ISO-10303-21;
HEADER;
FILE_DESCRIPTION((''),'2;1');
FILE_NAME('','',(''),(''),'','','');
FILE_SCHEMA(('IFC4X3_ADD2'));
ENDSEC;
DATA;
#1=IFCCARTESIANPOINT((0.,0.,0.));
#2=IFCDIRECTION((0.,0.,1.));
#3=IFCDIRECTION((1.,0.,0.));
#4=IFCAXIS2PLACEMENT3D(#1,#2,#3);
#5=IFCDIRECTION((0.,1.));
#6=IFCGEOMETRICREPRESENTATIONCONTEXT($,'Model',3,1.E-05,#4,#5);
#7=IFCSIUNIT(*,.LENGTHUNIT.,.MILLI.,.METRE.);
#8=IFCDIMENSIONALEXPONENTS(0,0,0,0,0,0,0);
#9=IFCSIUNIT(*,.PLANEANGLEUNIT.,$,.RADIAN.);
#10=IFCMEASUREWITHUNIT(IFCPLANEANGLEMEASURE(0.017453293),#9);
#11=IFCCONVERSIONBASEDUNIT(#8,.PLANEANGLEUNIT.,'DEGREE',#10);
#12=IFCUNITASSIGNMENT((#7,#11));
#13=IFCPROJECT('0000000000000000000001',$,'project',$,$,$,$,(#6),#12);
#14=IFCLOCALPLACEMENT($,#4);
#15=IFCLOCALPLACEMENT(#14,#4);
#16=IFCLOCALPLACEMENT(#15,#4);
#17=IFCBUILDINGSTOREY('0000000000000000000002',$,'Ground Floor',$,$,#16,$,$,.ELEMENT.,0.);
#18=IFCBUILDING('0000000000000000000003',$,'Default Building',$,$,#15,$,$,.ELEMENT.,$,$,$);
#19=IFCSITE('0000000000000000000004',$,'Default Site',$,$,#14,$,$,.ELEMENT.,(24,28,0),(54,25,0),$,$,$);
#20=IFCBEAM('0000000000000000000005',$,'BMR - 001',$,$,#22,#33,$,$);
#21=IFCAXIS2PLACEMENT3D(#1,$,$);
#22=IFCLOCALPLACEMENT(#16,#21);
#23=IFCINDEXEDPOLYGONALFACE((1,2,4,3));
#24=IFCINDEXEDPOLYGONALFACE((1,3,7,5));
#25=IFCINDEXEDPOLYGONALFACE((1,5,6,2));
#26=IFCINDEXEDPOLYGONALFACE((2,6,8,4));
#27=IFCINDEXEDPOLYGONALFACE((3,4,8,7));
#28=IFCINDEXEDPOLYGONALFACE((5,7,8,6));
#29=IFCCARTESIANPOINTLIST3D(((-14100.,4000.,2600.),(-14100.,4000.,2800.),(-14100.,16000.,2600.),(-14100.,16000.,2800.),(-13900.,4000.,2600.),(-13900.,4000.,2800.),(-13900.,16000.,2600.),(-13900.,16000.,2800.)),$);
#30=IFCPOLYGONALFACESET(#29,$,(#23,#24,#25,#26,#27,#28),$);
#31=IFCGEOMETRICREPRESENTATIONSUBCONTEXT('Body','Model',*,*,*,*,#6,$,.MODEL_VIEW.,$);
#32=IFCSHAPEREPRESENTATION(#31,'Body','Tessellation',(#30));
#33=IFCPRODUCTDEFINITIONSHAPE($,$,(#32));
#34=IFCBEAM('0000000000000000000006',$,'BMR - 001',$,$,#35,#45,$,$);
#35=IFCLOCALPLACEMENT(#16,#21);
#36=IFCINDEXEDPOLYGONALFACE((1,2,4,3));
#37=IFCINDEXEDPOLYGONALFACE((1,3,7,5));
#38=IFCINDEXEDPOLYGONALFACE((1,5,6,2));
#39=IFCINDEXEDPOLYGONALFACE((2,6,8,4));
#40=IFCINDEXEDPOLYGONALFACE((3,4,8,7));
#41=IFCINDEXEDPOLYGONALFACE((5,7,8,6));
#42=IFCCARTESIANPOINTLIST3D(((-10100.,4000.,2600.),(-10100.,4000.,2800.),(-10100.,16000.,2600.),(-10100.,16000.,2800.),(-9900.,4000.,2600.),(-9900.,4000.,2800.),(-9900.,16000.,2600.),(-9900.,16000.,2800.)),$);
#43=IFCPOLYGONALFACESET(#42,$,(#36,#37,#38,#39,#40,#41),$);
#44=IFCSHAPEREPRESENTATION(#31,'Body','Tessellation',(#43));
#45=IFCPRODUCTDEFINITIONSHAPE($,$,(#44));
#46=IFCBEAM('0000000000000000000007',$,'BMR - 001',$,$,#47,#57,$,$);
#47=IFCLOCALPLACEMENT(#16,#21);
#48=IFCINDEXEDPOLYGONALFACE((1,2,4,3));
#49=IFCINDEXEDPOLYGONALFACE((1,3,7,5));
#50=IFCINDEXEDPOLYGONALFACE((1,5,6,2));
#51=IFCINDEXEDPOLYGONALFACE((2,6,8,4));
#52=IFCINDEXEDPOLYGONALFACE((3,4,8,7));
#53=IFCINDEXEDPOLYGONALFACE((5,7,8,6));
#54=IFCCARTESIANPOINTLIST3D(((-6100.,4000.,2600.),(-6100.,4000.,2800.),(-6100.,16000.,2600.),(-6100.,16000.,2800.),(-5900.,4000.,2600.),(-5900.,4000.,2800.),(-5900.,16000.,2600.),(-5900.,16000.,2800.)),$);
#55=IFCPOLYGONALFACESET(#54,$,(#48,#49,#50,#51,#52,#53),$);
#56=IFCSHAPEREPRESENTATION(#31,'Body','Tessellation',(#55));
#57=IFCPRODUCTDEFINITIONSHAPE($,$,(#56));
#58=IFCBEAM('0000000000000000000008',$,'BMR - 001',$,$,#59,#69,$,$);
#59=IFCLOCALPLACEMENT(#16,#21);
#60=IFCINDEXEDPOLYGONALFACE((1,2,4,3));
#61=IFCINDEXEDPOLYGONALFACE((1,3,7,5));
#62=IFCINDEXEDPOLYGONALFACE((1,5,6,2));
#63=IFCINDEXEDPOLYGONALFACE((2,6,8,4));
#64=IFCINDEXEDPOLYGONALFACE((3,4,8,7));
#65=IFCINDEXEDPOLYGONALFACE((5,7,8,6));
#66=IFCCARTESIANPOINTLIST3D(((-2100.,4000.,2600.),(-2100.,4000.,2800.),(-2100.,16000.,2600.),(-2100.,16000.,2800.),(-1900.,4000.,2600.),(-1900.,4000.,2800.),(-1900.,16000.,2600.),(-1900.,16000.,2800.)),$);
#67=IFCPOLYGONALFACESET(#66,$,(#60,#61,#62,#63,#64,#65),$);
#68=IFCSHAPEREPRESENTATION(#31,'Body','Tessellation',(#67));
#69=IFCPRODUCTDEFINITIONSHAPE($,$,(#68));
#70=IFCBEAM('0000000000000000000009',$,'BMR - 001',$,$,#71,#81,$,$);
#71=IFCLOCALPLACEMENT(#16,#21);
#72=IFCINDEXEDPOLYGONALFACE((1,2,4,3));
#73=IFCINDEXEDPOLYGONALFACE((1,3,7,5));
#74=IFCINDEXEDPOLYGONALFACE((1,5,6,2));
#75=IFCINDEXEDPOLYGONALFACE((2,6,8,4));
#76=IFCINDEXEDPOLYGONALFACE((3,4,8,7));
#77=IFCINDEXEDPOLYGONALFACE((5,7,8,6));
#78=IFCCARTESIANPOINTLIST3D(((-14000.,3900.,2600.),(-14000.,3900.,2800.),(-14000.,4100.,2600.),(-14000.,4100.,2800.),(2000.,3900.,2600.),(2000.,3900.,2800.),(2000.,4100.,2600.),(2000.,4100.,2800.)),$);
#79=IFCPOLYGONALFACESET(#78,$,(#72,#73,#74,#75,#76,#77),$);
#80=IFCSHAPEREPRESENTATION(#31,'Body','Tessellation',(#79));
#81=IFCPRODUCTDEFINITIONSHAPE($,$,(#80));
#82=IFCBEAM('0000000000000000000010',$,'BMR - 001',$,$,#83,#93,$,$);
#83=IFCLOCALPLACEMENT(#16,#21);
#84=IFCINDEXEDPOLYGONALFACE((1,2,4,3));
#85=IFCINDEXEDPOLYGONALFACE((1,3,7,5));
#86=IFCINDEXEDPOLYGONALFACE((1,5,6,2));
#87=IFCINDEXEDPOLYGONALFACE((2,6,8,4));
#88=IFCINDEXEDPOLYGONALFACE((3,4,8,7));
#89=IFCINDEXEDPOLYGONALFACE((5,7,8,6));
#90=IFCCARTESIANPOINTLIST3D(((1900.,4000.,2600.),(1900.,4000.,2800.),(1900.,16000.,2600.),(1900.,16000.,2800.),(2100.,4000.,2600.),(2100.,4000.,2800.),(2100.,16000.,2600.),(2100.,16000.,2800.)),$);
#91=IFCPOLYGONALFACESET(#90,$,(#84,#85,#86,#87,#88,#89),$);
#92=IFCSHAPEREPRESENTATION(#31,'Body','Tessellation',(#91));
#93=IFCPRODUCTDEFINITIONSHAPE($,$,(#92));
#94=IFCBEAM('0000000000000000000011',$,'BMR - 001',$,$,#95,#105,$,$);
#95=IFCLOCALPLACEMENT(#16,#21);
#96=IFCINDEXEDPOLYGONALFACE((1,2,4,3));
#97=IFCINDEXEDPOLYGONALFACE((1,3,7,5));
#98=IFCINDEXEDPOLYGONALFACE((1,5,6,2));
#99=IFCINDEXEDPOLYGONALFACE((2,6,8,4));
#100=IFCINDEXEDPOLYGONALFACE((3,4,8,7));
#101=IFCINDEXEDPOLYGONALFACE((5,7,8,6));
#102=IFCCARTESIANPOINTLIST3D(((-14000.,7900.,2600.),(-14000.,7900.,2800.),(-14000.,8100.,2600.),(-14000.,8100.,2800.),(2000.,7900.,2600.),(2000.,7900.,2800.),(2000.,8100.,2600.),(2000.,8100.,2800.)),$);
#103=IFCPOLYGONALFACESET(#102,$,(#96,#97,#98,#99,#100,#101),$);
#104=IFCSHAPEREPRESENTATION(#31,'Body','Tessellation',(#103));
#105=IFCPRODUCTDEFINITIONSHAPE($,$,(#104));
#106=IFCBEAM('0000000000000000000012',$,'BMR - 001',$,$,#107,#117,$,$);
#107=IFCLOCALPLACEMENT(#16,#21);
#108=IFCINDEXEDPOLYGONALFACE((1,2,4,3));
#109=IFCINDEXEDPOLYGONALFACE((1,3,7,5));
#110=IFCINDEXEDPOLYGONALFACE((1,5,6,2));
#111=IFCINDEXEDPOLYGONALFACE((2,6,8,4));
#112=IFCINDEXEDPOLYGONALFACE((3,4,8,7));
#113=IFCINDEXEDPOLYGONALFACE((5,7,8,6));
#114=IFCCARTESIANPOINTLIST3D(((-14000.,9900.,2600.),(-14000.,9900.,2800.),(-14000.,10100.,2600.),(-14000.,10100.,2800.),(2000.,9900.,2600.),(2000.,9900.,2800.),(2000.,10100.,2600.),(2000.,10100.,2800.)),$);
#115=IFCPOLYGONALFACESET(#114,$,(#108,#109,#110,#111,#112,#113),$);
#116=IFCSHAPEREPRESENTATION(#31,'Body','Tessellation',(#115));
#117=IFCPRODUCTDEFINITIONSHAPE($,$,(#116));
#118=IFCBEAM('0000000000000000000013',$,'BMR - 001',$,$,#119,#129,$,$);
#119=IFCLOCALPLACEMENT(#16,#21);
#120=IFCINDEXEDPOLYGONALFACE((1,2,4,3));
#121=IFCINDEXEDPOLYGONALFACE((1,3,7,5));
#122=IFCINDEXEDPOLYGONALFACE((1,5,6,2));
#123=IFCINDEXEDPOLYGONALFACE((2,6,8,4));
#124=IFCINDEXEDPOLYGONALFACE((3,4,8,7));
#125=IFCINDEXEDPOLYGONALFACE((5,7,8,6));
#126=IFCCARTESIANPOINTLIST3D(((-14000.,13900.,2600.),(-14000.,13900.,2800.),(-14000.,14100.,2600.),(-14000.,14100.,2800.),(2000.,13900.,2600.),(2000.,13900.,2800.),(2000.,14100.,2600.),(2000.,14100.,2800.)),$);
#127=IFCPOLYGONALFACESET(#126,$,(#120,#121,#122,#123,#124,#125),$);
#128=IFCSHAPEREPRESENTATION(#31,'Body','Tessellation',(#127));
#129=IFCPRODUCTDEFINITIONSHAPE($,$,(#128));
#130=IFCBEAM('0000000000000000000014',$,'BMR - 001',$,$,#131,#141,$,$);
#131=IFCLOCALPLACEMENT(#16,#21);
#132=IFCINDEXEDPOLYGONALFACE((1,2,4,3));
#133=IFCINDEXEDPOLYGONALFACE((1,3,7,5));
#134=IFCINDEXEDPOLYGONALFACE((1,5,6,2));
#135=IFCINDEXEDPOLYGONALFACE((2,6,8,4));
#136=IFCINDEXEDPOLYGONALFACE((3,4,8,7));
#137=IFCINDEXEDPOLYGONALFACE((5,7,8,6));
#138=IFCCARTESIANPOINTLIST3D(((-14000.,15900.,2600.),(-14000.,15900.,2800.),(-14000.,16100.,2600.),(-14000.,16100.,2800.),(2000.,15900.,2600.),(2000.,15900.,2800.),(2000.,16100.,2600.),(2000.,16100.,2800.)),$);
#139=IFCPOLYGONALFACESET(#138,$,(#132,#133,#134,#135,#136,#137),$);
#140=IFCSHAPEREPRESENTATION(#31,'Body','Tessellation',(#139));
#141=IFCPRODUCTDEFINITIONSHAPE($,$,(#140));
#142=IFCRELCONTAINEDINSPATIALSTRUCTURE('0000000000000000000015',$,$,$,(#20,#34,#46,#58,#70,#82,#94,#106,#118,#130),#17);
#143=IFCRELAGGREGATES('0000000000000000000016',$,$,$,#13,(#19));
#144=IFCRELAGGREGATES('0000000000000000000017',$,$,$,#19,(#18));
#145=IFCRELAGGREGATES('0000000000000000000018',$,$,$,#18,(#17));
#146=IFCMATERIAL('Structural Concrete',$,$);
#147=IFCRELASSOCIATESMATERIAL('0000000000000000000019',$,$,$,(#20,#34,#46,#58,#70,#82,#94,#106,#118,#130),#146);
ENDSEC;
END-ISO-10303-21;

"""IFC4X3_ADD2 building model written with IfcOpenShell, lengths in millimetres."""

from ifc_helpers import new_model, entity, si_unit, converted_unit, direction, frame, frame_2d, origin_with_axes, place, context, subcontext, project, spatial, rectangle, extrude, material, element, save


model = new_model("IFC4X3_ADD2")

# Units and contexts
model_context = context("Model", 3, precision=1e-05, world=origin_with_axes(), true_north=direction((0.0, 1.0)))
body_context = subcontext(model_context, "Body", "Model", "MODEL_VIEW")
ifc_project = project(units=[si_unit("LENGTHUNIT", "METRE", prefix="MILLI"), converted_unit("PLANEANGLEUNIT", "DEGREE", entity("IfcPlaneAngleMeasure", 0.017453293), si_unit("PLANEANGLEUNIT", "RADIAN"), dimensions=[0, 0, 0, 0, 0, 0, 0])], contexts=[model_context])

# Site, building, storey
site_placement = place(None, origin_with_axes())
site = spatial("IfcSite", under=ifc_project, at=site_placement, Name="Default Site", CompositionType="ELEMENT", RefLatitude=(24, 28, 0), RefLongitude=(54, 25, 0))
building_placement = place(site_placement, origin_with_axes())
building = spatial("IfcBuilding", under=site, at=building_placement, Name="Default Building", CompositionType="ELEMENT")
storey_placement = place(building_placement, origin_with_axes())
storey = spatial("IfcBuildingStorey", under=building, at=storey_placement, Name="Ground Floor", CompositionType="ELEMENT", Elevation=0.0)

# Beams
ifc_material = material(Name="Structural Concrete")
for number, where, z_axis, x_axis, name in (
    (1, (-14000.0, 4000.0, 2800.0), (0.0, 0.0, 1.0), (1.0, 0.0, 0.0), "BMR - 001"),
    (2, (-10000.0, 4000.0, 2800.0), (0.0, 0.0, 1.0), (1.0, 0.0, 0.0), "BMR - 001"),
    (3, (-6000.0, 4000.0, 2800.0), (0.0, 0.0, 1.0), (1.0, 0.0, 0.0), "BMR - 001"),
    (4, (-2000.0, 4000.0, 2800.0), (0.0, 0.0, 1.0), (1.0, 0.0, 0.0), "BMR - 001"),
):
    element("IfcBeam", number, at=place(storey_placement, frame(where, z_axis=z_axis, x_axis=x_axis)), inside=storey, material=ifc_material, Name=name, context=body_context, shape_type="SweptSolid", body=[
        extrude(rectangle(XDim=200.0, YDim=200.0, at=frame_2d((-100.0, 0.0), x_axis=(1.0, 0.0))), frame((0.0, 0.0, 0.0), z_axis=(0.0, 1.0, 0.0), x_axis=(0.0, 0.0, 1.0)), (0.0, 0.0, 1.0), 12000.0),
    ])
beam_1_placement = place(storey_placement, frame((-14000.0, 4000.0, 2800.0), z_axis=(0.0, 0.0, 1.0), x_axis=(0.0, -1.0, 0.0)))
element("IfcBeam", 5, at=beam_1_placement, inside=storey, material=ifc_material, Name="BMR - 001", context=body_context, shape_type="SweptSolid", body=[
    extrude(rectangle(XDim=200.0, YDim=200.0, at=frame_2d((-100.0, 0.0), x_axis=(1.0, 0.0))), frame((0.0, 0.0, 0.0), z_axis=(0.0, 1.0, 0.0), x_axis=(0.0, 0.0, 1.0)), (0.0, 0.0, 1.0), 16000.0),
])
beam_2_placement = place(storey_placement, frame((2000.0, 4000.0, 2800.0), z_axis=(0.0, 0.0, 1.0), x_axis=(1.0, 0.0, 0.0)))
element("IfcBeam", 6, at=beam_2_placement, inside=storey, material=ifc_material, Name="BMR - 001", context=body_context, shape_type="SweptSolid", body=[
    extrude(rectangle(XDim=200.0, YDim=200.0, at=frame_2d((-100.0, 0.0), x_axis=(1.0, 0.0))), frame((0.0, 0.0, 0.0), z_axis=(0.0, 1.0, 0.0), x_axis=(0.0, 0.0, 1.0)), (0.0, 0.0, 1.0), 12000.0),
])
for number, where, z_axis, x_axis, name in (
    (7, (-14000.0, 8000.0, 2800.0), (0.0, 0.0, 1.0), (0.0, -1.0, 0.0), "BMR - 001"),
    (8, (-14000.0, 10000.0, 2800.0), (0.0, 0.0, 1.0), (0.0, -1.0, 0.0), "BMR - 001"),
    (9, (-14000.0, 14000.0, 2800.0), (0.0, 0.0, 1.0), (0.0, -1.0, 0.0), "BMR - 001"),
    (10, (-14000.0, 16000.0, 2800.0), (0.0, 0.0, 1.0), (0.0, -1.0, 0.0), "BMR - 001"),
):
    element("IfcBeam", number, at=place(storey_placement, frame(where, z_axis=z_axis, x_axis=x_axis)), inside=storey, material=ifc_material, Name=name, context=body_context, shape_type="SweptSolid", body=[
        extrude(rectangle(XDim=200.0, YDim=200.0, at=frame_2d((-100.0, 0.0), x_axis=(1.0, 0.0))), frame((0.0, 0.0, 0.0), z_axis=(0.0, 1.0, 0.0), x_axis=(0.0, 0.0, 1.0)), (0.0, 0.0, 1.0), 16000.0),
    ])

save(model, "model.ifc")
